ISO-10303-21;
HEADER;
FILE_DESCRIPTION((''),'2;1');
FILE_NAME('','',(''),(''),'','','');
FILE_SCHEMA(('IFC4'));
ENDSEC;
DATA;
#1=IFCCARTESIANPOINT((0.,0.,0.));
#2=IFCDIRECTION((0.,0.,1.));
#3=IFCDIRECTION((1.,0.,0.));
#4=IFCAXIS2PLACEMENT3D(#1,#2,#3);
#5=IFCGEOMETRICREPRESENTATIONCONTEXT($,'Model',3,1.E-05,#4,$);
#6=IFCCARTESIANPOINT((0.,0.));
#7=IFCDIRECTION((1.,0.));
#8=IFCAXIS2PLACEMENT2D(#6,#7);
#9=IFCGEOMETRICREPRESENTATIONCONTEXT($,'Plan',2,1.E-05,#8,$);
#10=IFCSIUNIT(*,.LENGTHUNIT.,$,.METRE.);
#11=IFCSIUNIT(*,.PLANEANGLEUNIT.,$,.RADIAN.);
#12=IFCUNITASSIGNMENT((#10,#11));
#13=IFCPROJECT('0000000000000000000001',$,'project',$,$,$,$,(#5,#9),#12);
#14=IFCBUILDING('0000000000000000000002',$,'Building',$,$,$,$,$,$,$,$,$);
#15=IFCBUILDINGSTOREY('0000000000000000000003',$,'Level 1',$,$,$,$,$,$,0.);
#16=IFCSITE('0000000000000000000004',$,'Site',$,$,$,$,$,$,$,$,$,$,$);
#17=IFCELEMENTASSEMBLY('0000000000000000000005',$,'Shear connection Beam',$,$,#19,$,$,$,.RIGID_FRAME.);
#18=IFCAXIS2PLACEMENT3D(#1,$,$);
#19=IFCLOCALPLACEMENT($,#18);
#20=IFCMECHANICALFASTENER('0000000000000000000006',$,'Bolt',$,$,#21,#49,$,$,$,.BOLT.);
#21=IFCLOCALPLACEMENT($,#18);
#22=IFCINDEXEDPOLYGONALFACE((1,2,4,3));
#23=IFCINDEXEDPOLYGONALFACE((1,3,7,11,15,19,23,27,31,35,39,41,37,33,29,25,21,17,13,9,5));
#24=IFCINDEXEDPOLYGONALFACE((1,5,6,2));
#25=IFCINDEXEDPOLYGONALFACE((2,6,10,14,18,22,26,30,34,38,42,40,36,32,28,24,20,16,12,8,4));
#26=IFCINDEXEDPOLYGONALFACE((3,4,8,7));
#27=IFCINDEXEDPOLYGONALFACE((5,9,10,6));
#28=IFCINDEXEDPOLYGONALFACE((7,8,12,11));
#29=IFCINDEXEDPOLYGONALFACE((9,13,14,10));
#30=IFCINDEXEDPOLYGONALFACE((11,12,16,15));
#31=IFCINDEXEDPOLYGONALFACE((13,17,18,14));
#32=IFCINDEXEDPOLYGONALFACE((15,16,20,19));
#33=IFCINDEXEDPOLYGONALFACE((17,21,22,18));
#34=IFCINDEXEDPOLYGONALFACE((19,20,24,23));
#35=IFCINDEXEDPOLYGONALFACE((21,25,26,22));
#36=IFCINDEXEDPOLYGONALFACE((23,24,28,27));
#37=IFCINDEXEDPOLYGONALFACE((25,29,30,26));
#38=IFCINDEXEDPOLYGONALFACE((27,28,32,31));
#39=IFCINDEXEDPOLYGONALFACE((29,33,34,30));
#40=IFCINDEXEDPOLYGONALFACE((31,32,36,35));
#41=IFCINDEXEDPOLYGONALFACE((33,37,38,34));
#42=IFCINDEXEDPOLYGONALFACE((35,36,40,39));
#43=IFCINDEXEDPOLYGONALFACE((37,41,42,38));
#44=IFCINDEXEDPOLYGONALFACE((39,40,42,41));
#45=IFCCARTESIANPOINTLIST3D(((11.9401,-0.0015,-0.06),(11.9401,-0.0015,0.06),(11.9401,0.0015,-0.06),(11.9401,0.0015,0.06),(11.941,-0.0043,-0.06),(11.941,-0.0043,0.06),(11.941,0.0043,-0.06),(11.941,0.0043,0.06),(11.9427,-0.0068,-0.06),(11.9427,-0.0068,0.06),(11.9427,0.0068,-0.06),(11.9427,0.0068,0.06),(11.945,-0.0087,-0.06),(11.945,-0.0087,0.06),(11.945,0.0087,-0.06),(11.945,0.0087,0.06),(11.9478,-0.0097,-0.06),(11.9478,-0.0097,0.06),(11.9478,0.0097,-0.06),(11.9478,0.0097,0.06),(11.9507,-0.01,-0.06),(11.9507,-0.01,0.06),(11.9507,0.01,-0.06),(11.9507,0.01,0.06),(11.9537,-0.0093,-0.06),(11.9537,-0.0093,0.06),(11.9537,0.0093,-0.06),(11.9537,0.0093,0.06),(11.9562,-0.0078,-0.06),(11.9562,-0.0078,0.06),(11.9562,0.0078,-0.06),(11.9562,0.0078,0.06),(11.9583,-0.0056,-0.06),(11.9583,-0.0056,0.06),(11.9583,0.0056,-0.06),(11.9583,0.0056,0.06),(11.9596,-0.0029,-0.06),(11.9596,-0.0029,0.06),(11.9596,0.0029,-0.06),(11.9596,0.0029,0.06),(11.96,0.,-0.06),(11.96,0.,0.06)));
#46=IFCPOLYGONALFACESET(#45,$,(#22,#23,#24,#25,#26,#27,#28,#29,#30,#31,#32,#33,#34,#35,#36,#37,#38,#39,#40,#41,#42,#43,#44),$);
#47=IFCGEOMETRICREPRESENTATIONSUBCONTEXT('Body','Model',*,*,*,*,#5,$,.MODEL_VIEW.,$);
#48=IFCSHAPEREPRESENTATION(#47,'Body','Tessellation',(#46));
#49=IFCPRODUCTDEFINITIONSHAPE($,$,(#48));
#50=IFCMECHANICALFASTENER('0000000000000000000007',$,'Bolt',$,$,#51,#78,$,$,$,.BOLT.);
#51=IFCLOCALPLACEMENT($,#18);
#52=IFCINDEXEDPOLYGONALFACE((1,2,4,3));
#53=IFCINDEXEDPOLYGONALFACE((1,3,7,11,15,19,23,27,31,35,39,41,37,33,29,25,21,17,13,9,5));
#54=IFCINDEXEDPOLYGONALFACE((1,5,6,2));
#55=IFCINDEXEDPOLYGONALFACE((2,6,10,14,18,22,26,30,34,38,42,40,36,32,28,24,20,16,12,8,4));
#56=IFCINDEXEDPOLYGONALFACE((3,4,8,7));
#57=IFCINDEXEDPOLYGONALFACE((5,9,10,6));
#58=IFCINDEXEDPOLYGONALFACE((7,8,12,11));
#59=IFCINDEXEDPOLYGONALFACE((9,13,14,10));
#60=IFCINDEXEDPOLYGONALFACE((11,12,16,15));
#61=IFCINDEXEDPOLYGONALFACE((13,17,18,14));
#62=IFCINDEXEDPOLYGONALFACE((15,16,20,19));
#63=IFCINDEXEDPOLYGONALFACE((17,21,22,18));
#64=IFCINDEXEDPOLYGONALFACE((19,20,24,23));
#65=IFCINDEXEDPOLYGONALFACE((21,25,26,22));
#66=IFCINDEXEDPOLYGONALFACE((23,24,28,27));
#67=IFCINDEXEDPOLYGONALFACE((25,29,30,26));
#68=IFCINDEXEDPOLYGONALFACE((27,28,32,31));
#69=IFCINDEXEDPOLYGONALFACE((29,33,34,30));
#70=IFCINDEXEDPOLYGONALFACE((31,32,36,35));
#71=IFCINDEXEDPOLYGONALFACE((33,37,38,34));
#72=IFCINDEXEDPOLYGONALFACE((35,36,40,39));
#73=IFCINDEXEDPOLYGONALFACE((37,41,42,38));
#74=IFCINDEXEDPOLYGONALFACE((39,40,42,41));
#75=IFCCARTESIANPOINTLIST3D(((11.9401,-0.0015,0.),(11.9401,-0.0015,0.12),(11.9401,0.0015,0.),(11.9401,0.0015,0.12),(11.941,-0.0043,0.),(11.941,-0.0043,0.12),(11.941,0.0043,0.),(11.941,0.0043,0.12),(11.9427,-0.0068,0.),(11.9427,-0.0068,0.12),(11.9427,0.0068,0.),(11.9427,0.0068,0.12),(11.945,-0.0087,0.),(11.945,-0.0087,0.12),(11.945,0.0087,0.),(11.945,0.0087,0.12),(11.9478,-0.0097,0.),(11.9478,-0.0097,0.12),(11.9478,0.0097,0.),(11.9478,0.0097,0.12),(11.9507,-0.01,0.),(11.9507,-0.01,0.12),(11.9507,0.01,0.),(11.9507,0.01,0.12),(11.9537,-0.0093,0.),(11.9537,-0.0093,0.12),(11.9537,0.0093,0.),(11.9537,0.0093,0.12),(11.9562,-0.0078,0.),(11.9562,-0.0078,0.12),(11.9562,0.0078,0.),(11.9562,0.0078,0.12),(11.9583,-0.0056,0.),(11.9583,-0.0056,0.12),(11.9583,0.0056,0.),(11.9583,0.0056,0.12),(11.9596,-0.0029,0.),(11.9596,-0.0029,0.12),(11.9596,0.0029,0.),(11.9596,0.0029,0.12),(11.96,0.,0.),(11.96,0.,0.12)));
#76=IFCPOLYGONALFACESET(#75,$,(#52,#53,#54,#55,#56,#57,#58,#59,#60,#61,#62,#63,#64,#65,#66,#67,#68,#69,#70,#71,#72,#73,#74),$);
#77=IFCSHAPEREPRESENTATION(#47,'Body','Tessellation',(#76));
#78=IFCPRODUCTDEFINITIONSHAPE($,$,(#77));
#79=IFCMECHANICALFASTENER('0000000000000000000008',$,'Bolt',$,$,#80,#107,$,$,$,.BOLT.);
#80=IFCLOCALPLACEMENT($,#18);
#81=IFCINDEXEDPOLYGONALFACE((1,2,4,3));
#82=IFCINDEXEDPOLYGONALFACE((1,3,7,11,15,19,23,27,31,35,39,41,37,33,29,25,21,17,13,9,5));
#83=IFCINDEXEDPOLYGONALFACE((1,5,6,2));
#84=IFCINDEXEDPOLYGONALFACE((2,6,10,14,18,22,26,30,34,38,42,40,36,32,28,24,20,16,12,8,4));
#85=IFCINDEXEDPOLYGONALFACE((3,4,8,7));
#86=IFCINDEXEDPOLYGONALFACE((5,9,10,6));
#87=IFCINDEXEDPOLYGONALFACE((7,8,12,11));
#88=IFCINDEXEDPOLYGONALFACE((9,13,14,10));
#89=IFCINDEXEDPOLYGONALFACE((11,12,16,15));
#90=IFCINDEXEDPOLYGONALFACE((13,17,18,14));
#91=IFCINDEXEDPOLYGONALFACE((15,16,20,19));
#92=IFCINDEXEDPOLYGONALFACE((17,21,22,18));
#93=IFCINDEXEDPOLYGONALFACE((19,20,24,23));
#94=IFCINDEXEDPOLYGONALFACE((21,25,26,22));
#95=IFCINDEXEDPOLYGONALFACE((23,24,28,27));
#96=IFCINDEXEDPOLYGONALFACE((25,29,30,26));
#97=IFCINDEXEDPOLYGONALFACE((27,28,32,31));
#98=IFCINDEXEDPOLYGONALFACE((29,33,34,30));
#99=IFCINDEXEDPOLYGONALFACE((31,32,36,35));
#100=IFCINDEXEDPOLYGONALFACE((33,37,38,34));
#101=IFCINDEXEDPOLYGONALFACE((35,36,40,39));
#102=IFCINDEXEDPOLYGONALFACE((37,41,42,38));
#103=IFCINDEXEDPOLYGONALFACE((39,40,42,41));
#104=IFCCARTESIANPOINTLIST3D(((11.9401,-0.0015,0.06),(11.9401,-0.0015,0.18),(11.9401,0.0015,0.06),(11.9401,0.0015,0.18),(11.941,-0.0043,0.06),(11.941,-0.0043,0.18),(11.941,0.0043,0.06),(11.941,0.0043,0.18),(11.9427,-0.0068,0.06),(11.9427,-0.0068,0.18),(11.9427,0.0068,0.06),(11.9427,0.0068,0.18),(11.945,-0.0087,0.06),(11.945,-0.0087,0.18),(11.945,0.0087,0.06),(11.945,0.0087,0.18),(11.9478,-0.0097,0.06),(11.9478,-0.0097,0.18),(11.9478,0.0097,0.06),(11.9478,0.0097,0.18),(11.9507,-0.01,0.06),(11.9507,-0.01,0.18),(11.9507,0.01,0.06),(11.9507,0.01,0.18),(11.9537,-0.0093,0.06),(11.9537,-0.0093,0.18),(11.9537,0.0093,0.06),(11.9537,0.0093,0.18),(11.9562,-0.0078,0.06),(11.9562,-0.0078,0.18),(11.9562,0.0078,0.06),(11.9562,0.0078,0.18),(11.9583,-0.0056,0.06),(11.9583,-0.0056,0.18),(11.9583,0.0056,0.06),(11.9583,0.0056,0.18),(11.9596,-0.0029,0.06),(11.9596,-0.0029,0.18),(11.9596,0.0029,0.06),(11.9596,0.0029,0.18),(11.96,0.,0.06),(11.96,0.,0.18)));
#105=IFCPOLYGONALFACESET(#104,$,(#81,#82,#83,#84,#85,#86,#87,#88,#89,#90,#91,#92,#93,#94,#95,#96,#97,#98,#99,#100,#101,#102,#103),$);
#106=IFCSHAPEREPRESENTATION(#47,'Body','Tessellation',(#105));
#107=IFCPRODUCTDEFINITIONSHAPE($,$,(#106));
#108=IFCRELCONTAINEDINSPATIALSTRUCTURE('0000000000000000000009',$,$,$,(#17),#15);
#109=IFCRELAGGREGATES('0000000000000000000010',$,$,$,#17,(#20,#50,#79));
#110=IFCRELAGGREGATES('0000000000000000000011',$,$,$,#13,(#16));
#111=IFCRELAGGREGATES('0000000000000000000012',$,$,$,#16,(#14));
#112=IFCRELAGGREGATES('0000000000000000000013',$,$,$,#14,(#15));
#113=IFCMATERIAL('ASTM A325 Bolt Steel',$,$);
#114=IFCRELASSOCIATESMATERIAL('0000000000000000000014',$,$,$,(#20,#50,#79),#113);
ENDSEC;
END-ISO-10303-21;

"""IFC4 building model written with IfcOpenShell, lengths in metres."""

from ifc_helpers import new_model, si_unit, frame, origin_with_axes, origin_2d, origin_2d_with_axis, place, context, subcontext, project, spatial, circle, extrude, material, element, aggregate, save


model = new_model("IFC4")

# Units and contexts
model_context = context("Model", 3, precision=1e-05, world=origin_with_axes())
plan_context = context("Plan", 2, precision=1e-05, world=origin_2d_with_axis())
body_context = subcontext(model_context, "Body", "Model", "MODEL_VIEW")
ifc_project = project(units=[si_unit("LENGTHUNIT", "METRE"), si_unit("PLANEANGLEUNIT", "RADIAN")], contexts=[model_context, plan_context])

# Site, building, storey
site = spatial("IfcSite", under=ifc_project, Name="Site")
building = spatial("IfcBuilding", under=site, Name="Building")
storey = spatial("IfcBuildingStorey", under=building, Name="Level 1", Elevation=0.0)

# Element assembly
assembly_1 = element("IfcElementAssembly", 1, inside=storey, Name="Shear connection Beam", PredefinedType="RIGID_FRAME")

# Shared definitions
ifc_material_1 = material(Name="ASTM A325 Bolt Steel")

# Mechanical fasteners
mechanical_fastener_1_placement = place(None, frame((11.95, 0.0, -0.06), z_axis=(0.0, 0.0, 1.0), x_axis=(1.0, 0.0, 0.0)))
mechanical_fastener_1 = element("IfcMechanicalFastener", 2, at=mechanical_fastener_1_placement, material=ifc_material_1, Name="Bolt", PredefinedType="BOLT", context=body_context, shape_type="SweptSolid", body=[
    extrude(circle(Radius=0.01, at=origin_2d()), origin_with_axes(), (0.0, 0.0, 1.0), 0.12),
])
mechanical_fastener_2_placement = place(None, frame((11.95, 0.0, 0.0), z_axis=(0.0, 0.0, 1.0), x_axis=(1.0, 0.0, 0.0)))
mechanical_fastener_2 = element("IfcMechanicalFastener", 3, at=mechanical_fastener_2_placement, material=ifc_material_1, Name="Bolt", PredefinedType="BOLT", context=body_context, shape_type="SweptSolid", body=[
    extrude(circle(Radius=0.01, at=origin_2d()), origin_with_axes(), (0.0, 0.0, 1.0), 0.12),
])
mechanical_fastener_3_placement = place(None, frame((11.95, 0.0, 0.06), z_axis=(0.0, 0.0, 1.0), x_axis=(1.0, 0.0, 0.0)))
mechanical_fastener_3 = element("IfcMechanicalFastener", 4, at=mechanical_fastener_3_placement, material=ifc_material_1, Name="Bolt", PredefinedType="BOLT", context=body_context, shape_type="SweptSolid", body=[
    extrude(circle(Radius=0.01, at=origin_2d()), origin_with_axes(), (0.0, 0.0, 1.0), 0.12),
])
aggregate(assembly_1, [mechanical_fastener_1, mechanical_fastener_2, mechanical_fastener_3])

save(model, "model.ifc")
